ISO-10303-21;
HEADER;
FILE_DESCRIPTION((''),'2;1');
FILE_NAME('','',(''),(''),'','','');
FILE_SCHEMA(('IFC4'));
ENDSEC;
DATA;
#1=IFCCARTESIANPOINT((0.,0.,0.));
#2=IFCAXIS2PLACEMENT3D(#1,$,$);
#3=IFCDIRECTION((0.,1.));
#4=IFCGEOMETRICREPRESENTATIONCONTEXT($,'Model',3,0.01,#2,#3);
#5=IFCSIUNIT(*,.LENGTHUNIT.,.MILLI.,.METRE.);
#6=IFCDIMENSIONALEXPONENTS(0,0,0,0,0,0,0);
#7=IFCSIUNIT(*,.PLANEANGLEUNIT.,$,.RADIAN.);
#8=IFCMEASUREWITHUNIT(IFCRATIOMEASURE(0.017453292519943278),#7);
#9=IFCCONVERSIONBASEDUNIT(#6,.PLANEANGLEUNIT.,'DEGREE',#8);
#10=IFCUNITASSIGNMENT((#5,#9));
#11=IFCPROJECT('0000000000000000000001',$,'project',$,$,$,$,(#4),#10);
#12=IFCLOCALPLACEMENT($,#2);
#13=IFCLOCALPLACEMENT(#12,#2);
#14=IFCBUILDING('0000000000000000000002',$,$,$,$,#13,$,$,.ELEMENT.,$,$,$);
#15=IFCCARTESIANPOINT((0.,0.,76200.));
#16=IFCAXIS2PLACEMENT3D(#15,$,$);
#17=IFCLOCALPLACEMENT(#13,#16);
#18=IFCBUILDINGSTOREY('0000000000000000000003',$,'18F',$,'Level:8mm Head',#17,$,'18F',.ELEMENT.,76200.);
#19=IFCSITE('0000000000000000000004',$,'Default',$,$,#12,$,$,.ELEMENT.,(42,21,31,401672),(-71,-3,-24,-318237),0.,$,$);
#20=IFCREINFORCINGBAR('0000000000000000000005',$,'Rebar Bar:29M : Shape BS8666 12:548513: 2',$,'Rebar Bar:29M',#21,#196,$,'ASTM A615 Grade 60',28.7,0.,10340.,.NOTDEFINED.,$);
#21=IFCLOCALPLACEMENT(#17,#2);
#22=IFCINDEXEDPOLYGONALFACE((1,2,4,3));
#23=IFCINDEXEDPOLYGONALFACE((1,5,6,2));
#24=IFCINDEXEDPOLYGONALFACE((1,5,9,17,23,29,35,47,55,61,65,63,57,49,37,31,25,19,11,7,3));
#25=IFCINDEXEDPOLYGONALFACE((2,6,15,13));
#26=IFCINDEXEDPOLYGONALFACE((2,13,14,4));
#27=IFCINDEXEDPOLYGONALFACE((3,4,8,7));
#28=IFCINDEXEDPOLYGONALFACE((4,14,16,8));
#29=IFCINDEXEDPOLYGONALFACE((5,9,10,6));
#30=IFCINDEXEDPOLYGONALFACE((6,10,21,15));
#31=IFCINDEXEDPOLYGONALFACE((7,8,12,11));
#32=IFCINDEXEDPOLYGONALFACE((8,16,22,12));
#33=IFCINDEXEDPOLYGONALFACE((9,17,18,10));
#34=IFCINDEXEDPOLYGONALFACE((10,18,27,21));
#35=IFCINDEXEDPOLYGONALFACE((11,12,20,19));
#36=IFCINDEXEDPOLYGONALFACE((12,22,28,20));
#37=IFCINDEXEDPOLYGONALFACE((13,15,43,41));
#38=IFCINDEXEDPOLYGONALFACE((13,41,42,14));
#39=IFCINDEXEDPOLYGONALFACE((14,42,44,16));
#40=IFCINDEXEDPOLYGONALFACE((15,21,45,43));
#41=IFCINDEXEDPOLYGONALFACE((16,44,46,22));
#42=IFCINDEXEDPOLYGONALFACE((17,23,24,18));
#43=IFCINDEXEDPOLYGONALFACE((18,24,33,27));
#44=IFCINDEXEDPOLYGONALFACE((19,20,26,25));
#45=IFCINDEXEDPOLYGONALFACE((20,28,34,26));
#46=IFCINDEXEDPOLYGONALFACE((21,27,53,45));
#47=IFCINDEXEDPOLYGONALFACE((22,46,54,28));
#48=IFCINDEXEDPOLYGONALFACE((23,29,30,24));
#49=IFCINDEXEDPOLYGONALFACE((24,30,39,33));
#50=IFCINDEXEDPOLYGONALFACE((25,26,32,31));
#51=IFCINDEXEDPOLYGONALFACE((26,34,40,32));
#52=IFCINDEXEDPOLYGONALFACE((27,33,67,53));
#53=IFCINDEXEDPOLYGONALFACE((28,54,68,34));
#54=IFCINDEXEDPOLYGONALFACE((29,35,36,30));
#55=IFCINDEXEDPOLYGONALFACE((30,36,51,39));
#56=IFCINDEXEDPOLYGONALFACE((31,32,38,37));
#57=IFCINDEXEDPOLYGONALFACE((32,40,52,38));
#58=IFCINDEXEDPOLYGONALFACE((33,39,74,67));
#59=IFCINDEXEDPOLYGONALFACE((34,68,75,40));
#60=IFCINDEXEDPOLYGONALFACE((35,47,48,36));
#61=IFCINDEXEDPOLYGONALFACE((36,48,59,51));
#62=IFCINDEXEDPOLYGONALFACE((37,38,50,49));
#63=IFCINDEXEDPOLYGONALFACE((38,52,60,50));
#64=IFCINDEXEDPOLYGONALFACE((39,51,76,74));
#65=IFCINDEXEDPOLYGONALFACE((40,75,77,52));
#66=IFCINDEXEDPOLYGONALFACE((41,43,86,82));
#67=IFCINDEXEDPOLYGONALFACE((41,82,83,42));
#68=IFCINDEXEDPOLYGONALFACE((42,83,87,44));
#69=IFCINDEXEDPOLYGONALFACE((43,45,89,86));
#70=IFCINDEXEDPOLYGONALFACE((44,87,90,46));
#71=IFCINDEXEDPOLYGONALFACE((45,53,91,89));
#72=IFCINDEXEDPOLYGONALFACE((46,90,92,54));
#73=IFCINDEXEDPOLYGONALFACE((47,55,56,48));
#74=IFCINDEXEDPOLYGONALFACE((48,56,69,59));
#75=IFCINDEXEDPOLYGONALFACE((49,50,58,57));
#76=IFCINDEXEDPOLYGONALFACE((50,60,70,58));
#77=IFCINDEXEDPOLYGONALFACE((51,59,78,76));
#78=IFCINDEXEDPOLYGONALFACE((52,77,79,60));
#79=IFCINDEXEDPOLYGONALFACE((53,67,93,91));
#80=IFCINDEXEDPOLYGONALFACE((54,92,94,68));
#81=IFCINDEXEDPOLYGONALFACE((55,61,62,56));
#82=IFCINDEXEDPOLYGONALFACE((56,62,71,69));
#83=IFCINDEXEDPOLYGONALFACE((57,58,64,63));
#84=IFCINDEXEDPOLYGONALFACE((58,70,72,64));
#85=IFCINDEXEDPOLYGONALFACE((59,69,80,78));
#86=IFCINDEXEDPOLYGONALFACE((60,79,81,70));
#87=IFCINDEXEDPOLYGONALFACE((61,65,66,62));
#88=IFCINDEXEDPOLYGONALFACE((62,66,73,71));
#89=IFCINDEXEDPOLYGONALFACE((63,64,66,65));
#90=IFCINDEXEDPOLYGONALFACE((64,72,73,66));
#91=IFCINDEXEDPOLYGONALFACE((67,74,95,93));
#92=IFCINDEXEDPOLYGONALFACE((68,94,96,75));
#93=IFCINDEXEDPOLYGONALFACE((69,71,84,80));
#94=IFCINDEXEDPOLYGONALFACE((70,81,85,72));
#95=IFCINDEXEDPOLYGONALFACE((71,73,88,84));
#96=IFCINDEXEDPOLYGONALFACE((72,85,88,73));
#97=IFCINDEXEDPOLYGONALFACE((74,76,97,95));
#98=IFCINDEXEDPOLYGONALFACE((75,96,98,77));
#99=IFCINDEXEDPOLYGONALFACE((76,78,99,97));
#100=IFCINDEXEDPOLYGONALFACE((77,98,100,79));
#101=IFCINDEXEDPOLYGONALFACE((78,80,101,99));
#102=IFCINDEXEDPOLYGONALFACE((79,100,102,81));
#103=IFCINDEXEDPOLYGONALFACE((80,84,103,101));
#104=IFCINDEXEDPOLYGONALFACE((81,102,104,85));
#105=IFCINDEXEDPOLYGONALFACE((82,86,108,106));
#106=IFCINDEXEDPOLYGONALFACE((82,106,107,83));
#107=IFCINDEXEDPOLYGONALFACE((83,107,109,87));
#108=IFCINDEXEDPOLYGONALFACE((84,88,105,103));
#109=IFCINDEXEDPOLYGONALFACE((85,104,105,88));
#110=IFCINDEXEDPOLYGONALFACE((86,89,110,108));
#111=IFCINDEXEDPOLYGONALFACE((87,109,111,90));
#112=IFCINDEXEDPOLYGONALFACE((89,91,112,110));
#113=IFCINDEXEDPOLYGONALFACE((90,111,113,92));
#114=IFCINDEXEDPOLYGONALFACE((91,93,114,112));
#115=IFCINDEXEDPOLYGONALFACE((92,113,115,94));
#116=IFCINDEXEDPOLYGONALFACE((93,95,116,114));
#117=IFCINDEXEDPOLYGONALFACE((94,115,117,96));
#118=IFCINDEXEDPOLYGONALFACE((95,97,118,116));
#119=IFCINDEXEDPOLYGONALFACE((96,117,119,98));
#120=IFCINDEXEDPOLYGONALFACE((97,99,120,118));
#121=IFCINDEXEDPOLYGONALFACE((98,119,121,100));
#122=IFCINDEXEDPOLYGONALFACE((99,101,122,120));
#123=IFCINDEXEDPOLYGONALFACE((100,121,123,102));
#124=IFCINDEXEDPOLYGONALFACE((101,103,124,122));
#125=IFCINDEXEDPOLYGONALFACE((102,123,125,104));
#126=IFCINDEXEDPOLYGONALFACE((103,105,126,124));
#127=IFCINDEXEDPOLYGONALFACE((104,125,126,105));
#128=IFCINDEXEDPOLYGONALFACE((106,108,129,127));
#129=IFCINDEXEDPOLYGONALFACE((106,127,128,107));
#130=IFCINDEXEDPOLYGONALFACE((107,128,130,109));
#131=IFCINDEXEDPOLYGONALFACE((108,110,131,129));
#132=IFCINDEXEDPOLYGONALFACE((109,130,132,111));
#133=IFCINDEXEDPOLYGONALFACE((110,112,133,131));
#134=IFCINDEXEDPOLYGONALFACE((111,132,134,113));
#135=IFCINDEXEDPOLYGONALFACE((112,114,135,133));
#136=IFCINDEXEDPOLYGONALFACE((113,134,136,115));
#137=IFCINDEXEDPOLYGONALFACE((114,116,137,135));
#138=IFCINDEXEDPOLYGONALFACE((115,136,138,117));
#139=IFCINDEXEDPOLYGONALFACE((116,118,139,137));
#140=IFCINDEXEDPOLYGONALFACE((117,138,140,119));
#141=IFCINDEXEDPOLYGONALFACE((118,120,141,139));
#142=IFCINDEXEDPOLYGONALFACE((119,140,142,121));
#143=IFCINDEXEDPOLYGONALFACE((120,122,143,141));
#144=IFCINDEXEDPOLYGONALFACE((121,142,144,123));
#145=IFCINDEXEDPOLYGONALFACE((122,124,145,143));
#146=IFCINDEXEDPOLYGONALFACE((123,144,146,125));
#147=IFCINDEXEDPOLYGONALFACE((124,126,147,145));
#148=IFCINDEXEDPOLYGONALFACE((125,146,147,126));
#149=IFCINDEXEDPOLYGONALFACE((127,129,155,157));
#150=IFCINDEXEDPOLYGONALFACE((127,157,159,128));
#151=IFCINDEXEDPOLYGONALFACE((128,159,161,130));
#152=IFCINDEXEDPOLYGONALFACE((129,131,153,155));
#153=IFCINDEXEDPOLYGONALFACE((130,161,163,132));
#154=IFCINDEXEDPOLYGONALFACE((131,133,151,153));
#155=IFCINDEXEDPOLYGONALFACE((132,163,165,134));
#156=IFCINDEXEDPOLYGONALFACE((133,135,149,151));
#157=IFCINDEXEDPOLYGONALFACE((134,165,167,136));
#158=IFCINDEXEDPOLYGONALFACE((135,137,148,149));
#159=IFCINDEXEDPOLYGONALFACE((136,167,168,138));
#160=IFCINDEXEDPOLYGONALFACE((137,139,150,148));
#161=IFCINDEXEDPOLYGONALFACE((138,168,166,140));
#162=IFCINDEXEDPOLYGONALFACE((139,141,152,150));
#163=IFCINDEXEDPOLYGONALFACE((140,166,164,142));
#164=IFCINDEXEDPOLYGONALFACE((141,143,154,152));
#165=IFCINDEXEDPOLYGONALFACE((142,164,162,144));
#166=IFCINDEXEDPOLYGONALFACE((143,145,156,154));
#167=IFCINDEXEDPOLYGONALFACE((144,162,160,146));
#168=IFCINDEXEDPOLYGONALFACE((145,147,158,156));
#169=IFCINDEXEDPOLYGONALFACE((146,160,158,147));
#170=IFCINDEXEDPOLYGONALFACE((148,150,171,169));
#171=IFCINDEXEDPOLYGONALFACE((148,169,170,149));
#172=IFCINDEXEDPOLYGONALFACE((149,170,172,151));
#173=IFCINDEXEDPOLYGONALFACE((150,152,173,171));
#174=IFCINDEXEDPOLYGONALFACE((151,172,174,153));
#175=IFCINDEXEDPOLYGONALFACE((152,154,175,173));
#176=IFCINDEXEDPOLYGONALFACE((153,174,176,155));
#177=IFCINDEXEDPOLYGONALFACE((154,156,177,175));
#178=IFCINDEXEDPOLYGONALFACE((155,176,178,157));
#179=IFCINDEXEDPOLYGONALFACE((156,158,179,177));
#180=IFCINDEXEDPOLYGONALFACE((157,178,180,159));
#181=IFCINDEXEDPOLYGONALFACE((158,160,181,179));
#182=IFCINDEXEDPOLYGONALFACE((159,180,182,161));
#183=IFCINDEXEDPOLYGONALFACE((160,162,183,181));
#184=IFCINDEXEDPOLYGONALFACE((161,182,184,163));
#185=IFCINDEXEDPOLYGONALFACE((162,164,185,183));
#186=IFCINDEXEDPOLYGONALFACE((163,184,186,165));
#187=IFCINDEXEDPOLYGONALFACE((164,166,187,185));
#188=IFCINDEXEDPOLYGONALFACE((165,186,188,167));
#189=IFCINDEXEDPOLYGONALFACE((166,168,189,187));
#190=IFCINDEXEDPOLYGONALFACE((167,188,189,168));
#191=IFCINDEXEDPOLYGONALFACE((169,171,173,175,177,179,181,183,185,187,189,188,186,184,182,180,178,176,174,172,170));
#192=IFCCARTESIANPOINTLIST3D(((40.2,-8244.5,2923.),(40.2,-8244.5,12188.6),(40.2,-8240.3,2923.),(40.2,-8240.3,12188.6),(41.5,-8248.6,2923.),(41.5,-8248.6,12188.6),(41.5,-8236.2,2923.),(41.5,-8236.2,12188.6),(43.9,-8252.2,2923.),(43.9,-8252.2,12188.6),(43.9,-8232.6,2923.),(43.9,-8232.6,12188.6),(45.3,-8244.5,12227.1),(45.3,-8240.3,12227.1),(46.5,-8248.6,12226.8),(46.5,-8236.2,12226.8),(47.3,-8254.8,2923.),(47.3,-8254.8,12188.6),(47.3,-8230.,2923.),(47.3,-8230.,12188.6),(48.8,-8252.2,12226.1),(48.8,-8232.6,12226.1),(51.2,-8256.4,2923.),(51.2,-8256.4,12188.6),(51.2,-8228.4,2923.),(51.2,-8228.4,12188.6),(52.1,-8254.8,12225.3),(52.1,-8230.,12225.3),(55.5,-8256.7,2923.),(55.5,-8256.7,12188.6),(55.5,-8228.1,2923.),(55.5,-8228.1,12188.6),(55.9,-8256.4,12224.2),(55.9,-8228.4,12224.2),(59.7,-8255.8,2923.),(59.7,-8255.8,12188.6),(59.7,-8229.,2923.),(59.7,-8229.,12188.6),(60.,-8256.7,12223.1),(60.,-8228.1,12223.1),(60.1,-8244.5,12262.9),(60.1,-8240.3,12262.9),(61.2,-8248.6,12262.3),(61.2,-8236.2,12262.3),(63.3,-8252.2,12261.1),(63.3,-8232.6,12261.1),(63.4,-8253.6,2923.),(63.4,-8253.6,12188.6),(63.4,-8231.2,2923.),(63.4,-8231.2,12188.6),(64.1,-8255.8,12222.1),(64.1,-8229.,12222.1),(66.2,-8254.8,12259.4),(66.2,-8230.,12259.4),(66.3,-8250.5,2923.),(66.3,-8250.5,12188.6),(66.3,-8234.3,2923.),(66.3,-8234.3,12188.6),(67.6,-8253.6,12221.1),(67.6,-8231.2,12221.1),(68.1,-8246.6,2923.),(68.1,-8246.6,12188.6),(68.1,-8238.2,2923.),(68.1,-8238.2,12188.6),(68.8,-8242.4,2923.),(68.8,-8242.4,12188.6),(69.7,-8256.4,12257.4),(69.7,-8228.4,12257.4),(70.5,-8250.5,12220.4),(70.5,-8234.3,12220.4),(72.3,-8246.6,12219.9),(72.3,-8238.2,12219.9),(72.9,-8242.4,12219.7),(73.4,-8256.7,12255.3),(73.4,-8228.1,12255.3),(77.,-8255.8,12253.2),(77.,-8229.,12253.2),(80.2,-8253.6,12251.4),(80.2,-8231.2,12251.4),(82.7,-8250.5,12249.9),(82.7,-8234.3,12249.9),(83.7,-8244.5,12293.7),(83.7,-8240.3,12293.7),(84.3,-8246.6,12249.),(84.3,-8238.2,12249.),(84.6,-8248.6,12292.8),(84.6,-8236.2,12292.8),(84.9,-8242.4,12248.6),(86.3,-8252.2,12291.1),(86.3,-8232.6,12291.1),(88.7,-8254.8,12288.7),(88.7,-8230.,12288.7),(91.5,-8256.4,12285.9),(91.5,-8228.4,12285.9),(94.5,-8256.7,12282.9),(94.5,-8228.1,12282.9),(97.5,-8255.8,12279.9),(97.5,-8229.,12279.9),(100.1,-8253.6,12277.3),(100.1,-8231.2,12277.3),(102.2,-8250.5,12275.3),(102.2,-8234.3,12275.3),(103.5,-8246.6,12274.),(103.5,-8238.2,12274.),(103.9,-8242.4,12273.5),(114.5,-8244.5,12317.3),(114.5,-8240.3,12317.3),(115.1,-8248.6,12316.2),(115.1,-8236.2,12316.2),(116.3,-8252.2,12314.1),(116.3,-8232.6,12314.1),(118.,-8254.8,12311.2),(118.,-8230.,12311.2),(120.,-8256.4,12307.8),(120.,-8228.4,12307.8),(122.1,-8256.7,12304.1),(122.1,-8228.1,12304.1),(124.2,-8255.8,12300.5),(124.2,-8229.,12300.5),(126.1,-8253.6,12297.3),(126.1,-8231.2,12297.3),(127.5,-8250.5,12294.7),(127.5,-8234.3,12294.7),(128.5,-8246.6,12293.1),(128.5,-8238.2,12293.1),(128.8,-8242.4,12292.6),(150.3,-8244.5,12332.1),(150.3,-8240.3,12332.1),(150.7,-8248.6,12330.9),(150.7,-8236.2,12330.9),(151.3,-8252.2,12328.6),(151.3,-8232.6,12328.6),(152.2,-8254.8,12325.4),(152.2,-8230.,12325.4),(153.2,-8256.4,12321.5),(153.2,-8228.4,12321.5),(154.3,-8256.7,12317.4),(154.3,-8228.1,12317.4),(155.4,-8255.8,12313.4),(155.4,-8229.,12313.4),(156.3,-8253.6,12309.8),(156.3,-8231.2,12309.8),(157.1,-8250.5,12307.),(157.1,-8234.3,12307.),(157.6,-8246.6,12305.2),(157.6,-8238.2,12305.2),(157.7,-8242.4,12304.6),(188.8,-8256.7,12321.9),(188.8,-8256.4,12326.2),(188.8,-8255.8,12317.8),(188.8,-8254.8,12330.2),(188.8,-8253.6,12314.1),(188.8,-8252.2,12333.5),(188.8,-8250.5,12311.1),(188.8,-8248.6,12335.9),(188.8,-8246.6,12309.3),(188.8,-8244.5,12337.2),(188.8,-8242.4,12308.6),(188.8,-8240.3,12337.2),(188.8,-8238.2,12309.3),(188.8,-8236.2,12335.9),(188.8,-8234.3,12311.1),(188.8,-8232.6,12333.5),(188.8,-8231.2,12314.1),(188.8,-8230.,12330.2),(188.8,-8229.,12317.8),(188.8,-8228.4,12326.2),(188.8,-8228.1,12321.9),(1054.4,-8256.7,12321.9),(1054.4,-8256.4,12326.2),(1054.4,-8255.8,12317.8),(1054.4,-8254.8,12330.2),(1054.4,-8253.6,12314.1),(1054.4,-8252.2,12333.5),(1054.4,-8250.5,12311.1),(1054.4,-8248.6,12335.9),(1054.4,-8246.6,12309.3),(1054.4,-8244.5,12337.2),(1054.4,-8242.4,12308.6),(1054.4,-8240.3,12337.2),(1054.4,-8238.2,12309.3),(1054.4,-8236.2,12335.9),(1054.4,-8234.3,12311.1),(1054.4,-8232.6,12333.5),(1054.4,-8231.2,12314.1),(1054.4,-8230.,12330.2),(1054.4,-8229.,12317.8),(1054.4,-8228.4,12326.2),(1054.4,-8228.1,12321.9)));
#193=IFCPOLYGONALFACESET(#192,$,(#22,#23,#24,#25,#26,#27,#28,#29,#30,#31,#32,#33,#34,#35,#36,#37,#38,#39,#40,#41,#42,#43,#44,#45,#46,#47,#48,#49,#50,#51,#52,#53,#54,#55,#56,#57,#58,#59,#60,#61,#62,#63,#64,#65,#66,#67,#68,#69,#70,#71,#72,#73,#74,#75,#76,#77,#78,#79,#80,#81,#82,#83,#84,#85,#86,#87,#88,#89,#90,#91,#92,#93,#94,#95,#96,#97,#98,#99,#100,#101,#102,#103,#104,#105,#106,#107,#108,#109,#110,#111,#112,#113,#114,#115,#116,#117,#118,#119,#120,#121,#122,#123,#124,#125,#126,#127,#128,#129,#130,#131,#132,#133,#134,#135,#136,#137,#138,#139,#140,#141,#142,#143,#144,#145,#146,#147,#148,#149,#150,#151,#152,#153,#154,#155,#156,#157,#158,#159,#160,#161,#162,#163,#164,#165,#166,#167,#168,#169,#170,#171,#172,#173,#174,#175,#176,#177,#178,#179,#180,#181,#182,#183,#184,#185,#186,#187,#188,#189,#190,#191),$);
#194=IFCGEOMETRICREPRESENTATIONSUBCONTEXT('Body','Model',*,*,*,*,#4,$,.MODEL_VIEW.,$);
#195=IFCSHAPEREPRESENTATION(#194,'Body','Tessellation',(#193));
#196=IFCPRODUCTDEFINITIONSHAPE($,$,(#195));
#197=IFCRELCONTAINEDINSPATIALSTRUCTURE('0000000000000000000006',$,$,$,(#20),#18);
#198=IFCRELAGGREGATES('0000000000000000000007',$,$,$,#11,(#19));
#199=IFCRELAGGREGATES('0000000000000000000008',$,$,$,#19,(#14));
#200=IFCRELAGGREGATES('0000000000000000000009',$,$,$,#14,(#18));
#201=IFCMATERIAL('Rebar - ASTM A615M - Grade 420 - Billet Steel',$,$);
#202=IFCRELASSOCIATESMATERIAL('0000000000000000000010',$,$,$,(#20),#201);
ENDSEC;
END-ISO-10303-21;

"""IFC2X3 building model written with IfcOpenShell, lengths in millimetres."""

from ifc_helpers import new_model, entity, si_unit, converted_unit, direction, frame, origin, place, context, subcontext, project, spatial, material, element, save


model = new_model("IFC2X3")

# Units and contexts
model_context = context("Model", 3, precision=0.01, world=origin(), true_north=direction((0.0, 1.0)))
body_context = subcontext(model_context, "Body", "Model", "MODEL_VIEW")
ifc_project = project(units=[si_unit("LENGTHUNIT", "METRE", prefix="MILLI"), converted_unit("PLANEANGLEUNIT", "DEGREE", entity("IfcRatioMeasure", 0.017453292519943278), si_unit("PLANEANGLEUNIT", "RADIAN"), dimensions=[0, 0, 0, 0, 0, 0, 0])], contexts=[model_context])

# Site, building, storey
site_placement = place(None, origin())
site = spatial("IfcSite", under=ifc_project, at=site_placement, Name="Default", CompositionType="ELEMENT", RefLatitude=(42, 21, 31, 401672), RefLongitude=(-71, -3, -24, -318237), RefElevation=0.0)
building_placement = place(site_placement, origin())
building = spatial("IfcBuilding", under=site, at=building_placement, CompositionType="ELEMENT")
storey_placement = place(building_placement, frame((0.0, 0.0, 76200.0)))
storey = spatial("IfcBuildingStorey", under=building, at=storey_placement, Name="18F", ObjectType="Level:8mm Head", LongName="18F", CompositionType="ELEMENT", Elevation=76200.0)

# Reinforcing bar
ifc_material_1 = material(Name="Rebar - ASTM A615M - Grade 420 - Billet Steel")
reinforcing_bar_1_placement = place(storey_placement, origin())
element("IfcReinforcingBar", 1, at=reinforcing_bar_1_placement, inside=storey, material=ifc_material_1, Name="Rebar Bar:29M : Shape BS8666 12:548513: 2", SteelGrade="ASTM A615 Grade 60", ObjectType="Rebar Bar:29M", BarLength=10340.0, BarRole="NOTDEFINED", CrossSectionArea=0.0, NominalDiameter=28.7, context=body_context, shape_type="AdvancedSweptSolid", body=[
    entity("IfcSweptDiskSolid", entity("IfcCompositeCurve", [entity("IfcCompositeCurveSegment", "CONTINUOUS", True, entity("IfcPolyline", [entity("IfcCartesianPoint", [54.4, -8242.4, 2923.0]), entity("IfcCartesianPoint", [54.4, -8242.4, 12188.6])])), entity("IfcCompositeCurveSegment", "CONTINUOUS", True, entity("IfcTrimmedCurve", entity("IfcCircle", entity("IfcAxis2Placement3D", entity("IfcCartesianPoint", [188.8, -8242.4, 12188.6]), entity("IfcDirection", [0.0, 1.0, 0.0]), entity("IfcDirection", [0.0, 0.0, 1.0])), 134.3), [entity("IfcParameterValue", 270.0)], [entity("IfcParameterValue", 360.0)], True, "PARAMETER")), entity("IfcCompositeCurveSegment", "CONTINUOUS", True, entity("IfcPolyline", [entity("IfcCartesianPoint", [188.8, -8242.4, 12323.0]), entity("IfcCartesianPoint", [1054.4, -8242.4, 12323.0])]))], False), 14.3, None, 0.0, 92.0),
])

save(model, "model.ifc")
